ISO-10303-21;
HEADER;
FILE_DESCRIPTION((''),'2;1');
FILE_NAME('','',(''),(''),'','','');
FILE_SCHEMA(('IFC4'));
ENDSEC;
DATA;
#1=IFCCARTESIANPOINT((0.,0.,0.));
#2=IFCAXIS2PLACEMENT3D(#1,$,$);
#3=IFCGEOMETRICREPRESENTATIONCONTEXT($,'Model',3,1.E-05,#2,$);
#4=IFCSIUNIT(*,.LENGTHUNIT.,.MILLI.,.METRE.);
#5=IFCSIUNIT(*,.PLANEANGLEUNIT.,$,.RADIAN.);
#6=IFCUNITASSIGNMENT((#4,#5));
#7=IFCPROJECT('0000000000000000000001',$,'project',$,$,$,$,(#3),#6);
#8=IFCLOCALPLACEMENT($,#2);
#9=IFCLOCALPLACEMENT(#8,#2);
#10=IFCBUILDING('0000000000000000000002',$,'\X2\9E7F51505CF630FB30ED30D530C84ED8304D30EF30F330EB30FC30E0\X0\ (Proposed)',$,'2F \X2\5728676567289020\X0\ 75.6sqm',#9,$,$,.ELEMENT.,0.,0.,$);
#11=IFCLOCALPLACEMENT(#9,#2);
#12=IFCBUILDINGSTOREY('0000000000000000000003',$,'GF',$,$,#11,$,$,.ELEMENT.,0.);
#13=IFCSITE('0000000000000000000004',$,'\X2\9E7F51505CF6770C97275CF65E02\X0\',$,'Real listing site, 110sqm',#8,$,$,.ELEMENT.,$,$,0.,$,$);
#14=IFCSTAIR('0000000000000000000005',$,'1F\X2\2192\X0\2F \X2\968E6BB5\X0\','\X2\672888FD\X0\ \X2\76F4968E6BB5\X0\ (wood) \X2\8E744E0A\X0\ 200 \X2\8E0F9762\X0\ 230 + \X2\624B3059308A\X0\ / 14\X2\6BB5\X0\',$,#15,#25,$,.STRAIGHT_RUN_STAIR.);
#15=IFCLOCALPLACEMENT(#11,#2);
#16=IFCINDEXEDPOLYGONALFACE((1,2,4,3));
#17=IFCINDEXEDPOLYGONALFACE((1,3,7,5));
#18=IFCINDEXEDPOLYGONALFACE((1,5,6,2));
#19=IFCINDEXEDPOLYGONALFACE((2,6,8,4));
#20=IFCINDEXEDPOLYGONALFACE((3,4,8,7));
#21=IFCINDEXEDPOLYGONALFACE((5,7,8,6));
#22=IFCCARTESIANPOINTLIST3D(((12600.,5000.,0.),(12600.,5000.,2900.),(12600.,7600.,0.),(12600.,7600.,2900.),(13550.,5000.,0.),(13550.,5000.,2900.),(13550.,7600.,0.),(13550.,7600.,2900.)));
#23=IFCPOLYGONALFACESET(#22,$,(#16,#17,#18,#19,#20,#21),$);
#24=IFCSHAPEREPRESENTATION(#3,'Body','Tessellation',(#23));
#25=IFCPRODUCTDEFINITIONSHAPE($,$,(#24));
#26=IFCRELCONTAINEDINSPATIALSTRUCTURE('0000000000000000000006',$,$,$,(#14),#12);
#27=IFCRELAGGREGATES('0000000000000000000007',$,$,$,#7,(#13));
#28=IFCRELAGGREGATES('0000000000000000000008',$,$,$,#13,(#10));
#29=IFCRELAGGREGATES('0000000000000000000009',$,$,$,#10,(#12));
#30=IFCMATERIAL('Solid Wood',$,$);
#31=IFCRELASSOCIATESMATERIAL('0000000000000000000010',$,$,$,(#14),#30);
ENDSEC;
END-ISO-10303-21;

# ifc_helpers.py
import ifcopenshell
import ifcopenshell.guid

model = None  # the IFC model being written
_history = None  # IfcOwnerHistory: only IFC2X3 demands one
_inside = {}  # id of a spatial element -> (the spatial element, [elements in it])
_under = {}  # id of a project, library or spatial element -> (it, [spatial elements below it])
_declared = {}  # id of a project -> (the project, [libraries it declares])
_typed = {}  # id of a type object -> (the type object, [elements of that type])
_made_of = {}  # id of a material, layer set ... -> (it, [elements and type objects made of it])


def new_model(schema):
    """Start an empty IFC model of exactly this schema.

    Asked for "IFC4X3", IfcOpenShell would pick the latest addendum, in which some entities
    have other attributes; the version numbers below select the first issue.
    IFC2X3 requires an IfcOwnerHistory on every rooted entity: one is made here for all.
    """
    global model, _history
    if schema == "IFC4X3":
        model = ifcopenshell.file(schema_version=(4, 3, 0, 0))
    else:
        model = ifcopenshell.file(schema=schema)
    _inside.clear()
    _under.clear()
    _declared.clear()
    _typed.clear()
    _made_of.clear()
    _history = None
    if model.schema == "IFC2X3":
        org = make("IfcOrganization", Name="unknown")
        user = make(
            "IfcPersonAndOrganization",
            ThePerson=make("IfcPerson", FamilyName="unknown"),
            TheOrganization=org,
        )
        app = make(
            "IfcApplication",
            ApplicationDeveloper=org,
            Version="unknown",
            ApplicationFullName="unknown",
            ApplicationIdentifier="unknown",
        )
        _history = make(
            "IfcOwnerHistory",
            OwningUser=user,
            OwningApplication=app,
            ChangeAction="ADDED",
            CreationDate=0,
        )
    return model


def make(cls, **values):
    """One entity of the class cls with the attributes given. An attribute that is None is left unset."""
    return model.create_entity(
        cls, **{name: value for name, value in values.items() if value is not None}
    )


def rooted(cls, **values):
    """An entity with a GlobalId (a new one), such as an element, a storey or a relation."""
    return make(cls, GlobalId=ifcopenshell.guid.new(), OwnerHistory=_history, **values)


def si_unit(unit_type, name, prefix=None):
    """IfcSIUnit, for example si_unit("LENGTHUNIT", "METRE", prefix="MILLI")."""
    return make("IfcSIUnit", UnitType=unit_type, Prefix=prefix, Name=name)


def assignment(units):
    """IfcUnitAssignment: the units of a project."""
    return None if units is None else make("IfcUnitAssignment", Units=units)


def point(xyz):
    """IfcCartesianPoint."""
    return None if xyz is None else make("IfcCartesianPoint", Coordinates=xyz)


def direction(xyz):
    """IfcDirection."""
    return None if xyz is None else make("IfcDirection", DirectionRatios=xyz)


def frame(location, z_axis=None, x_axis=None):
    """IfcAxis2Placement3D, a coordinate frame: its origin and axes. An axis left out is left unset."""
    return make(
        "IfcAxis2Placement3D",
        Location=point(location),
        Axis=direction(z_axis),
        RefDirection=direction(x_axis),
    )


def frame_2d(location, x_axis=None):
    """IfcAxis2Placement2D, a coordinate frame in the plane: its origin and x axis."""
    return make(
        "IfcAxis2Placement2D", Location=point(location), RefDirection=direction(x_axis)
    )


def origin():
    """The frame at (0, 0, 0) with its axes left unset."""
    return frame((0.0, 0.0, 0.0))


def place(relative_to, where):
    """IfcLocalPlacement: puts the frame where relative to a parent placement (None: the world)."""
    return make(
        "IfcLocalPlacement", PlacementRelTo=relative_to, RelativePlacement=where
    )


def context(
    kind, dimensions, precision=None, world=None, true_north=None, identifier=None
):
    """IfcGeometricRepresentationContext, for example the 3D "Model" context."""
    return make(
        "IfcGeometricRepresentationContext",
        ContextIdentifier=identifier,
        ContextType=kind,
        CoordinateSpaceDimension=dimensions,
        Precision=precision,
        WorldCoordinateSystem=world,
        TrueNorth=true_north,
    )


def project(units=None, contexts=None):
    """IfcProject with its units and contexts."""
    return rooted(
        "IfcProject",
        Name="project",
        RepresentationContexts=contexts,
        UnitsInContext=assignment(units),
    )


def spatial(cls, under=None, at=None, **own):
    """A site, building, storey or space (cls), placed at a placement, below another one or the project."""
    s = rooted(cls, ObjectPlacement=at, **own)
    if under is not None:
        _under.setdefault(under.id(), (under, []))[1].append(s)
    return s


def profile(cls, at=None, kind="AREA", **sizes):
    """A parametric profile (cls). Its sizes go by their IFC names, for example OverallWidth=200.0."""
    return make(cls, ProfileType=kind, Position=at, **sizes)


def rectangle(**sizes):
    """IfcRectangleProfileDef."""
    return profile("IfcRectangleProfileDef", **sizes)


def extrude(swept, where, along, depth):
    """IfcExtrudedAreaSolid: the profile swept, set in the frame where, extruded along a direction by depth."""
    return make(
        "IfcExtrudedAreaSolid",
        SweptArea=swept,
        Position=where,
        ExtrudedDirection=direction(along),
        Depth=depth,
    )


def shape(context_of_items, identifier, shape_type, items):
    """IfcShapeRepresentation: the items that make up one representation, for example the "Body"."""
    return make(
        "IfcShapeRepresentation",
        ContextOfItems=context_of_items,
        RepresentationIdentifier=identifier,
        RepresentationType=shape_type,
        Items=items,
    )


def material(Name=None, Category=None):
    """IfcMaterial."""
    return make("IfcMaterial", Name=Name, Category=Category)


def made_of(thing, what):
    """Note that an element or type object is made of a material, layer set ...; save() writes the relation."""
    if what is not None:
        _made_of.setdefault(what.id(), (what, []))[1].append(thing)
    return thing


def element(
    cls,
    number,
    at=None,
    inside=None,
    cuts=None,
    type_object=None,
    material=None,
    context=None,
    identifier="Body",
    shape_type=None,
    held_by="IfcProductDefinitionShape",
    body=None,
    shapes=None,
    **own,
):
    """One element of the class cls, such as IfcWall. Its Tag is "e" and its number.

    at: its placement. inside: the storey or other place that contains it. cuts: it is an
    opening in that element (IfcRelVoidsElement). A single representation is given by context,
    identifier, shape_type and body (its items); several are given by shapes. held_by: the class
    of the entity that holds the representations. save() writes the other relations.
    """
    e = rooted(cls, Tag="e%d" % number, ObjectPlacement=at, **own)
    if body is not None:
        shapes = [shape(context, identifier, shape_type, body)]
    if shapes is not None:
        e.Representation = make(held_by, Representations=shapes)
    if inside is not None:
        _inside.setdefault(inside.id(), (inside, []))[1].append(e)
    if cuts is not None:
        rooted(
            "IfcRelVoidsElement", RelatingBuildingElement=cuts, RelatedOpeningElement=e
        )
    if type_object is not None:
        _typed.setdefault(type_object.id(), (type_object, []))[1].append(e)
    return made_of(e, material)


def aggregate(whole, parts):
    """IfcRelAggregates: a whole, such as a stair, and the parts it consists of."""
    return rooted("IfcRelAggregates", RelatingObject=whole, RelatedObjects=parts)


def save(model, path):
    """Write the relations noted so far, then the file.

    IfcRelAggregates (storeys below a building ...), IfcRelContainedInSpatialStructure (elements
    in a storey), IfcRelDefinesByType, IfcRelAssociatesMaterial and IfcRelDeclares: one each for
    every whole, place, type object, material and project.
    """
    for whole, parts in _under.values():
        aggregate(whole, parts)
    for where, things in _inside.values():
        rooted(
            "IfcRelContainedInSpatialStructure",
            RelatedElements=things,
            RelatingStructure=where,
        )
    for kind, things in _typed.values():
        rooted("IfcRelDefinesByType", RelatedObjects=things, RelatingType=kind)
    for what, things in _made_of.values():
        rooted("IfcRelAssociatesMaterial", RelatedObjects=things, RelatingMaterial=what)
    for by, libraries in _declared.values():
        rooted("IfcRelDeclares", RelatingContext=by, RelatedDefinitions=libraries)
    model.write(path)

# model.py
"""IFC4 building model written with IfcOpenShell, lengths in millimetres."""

from ifc_helpers import new_model, si_unit, frame, frame_2d, origin, place, context, project, spatial, rectangle, extrude, material, element, save


model = new_model("IFC4")

# Units and contexts
model_context = context("Model", 3, precision=1e-05, world=origin())
ifc_project = project(units=[si_unit("LENGTHUNIT", "METRE", prefix="MILLI"), si_unit("PLANEANGLEUNIT", "RADIAN")], contexts=[model_context])

# Site, building, storey
site_placement = place(None, origin())
site = spatial("IfcSite", under=ifc_project, at=site_placement, Name="鹿児島県霧島市", ObjectType="Real listing site, 110sqm", CompositionType="ELEMENT", RefElevation=0.0)
building_placement = place(site_placement, origin())
building = spatial("IfcBuilding", under=site, at=building_placement, Name="鹿児島・ロフト付きワンルーム (Proposed)", ObjectType="2F 在来木造 75.6sqm", CompositionType="ELEMENT", ElevationOfRefHeight=0.0, ElevationOfTerrain=0.0)
storey_placement = place(building_placement, origin())
storey = spatial("IfcBuildingStorey", under=building, at=storey_placement, Name="GF", CompositionType="ELEMENT", Elevation=0.0)

# Shared definitions
ifc_material_1 = material(Name="Solid Wood")

# Stair
stair_1_placement = place(storey_placement, frame((6300.0, 2500.0, 0.0)))
element("IfcStair", 1, at=stair_1_placement, inside=storey, material=ifc_material_1, Name="1F→2F 階段", Description="木製 直階段 (wood) 蹴上 200 踏面 230 + 手すり / 14段", PredefinedType="STRAIGHT_RUN_STAIR", context=model_context, shape_type="SweptSolid", body=[
    extrude(rectangle(XDim=950.0, YDim=2600.0, at=frame_2d((475.0, 1300.0))), frame((6300.0, 2500.0, 0.0)), (0.0, 0.0, 1.0), 2900.0),
])

save(model, "model.ifc")
